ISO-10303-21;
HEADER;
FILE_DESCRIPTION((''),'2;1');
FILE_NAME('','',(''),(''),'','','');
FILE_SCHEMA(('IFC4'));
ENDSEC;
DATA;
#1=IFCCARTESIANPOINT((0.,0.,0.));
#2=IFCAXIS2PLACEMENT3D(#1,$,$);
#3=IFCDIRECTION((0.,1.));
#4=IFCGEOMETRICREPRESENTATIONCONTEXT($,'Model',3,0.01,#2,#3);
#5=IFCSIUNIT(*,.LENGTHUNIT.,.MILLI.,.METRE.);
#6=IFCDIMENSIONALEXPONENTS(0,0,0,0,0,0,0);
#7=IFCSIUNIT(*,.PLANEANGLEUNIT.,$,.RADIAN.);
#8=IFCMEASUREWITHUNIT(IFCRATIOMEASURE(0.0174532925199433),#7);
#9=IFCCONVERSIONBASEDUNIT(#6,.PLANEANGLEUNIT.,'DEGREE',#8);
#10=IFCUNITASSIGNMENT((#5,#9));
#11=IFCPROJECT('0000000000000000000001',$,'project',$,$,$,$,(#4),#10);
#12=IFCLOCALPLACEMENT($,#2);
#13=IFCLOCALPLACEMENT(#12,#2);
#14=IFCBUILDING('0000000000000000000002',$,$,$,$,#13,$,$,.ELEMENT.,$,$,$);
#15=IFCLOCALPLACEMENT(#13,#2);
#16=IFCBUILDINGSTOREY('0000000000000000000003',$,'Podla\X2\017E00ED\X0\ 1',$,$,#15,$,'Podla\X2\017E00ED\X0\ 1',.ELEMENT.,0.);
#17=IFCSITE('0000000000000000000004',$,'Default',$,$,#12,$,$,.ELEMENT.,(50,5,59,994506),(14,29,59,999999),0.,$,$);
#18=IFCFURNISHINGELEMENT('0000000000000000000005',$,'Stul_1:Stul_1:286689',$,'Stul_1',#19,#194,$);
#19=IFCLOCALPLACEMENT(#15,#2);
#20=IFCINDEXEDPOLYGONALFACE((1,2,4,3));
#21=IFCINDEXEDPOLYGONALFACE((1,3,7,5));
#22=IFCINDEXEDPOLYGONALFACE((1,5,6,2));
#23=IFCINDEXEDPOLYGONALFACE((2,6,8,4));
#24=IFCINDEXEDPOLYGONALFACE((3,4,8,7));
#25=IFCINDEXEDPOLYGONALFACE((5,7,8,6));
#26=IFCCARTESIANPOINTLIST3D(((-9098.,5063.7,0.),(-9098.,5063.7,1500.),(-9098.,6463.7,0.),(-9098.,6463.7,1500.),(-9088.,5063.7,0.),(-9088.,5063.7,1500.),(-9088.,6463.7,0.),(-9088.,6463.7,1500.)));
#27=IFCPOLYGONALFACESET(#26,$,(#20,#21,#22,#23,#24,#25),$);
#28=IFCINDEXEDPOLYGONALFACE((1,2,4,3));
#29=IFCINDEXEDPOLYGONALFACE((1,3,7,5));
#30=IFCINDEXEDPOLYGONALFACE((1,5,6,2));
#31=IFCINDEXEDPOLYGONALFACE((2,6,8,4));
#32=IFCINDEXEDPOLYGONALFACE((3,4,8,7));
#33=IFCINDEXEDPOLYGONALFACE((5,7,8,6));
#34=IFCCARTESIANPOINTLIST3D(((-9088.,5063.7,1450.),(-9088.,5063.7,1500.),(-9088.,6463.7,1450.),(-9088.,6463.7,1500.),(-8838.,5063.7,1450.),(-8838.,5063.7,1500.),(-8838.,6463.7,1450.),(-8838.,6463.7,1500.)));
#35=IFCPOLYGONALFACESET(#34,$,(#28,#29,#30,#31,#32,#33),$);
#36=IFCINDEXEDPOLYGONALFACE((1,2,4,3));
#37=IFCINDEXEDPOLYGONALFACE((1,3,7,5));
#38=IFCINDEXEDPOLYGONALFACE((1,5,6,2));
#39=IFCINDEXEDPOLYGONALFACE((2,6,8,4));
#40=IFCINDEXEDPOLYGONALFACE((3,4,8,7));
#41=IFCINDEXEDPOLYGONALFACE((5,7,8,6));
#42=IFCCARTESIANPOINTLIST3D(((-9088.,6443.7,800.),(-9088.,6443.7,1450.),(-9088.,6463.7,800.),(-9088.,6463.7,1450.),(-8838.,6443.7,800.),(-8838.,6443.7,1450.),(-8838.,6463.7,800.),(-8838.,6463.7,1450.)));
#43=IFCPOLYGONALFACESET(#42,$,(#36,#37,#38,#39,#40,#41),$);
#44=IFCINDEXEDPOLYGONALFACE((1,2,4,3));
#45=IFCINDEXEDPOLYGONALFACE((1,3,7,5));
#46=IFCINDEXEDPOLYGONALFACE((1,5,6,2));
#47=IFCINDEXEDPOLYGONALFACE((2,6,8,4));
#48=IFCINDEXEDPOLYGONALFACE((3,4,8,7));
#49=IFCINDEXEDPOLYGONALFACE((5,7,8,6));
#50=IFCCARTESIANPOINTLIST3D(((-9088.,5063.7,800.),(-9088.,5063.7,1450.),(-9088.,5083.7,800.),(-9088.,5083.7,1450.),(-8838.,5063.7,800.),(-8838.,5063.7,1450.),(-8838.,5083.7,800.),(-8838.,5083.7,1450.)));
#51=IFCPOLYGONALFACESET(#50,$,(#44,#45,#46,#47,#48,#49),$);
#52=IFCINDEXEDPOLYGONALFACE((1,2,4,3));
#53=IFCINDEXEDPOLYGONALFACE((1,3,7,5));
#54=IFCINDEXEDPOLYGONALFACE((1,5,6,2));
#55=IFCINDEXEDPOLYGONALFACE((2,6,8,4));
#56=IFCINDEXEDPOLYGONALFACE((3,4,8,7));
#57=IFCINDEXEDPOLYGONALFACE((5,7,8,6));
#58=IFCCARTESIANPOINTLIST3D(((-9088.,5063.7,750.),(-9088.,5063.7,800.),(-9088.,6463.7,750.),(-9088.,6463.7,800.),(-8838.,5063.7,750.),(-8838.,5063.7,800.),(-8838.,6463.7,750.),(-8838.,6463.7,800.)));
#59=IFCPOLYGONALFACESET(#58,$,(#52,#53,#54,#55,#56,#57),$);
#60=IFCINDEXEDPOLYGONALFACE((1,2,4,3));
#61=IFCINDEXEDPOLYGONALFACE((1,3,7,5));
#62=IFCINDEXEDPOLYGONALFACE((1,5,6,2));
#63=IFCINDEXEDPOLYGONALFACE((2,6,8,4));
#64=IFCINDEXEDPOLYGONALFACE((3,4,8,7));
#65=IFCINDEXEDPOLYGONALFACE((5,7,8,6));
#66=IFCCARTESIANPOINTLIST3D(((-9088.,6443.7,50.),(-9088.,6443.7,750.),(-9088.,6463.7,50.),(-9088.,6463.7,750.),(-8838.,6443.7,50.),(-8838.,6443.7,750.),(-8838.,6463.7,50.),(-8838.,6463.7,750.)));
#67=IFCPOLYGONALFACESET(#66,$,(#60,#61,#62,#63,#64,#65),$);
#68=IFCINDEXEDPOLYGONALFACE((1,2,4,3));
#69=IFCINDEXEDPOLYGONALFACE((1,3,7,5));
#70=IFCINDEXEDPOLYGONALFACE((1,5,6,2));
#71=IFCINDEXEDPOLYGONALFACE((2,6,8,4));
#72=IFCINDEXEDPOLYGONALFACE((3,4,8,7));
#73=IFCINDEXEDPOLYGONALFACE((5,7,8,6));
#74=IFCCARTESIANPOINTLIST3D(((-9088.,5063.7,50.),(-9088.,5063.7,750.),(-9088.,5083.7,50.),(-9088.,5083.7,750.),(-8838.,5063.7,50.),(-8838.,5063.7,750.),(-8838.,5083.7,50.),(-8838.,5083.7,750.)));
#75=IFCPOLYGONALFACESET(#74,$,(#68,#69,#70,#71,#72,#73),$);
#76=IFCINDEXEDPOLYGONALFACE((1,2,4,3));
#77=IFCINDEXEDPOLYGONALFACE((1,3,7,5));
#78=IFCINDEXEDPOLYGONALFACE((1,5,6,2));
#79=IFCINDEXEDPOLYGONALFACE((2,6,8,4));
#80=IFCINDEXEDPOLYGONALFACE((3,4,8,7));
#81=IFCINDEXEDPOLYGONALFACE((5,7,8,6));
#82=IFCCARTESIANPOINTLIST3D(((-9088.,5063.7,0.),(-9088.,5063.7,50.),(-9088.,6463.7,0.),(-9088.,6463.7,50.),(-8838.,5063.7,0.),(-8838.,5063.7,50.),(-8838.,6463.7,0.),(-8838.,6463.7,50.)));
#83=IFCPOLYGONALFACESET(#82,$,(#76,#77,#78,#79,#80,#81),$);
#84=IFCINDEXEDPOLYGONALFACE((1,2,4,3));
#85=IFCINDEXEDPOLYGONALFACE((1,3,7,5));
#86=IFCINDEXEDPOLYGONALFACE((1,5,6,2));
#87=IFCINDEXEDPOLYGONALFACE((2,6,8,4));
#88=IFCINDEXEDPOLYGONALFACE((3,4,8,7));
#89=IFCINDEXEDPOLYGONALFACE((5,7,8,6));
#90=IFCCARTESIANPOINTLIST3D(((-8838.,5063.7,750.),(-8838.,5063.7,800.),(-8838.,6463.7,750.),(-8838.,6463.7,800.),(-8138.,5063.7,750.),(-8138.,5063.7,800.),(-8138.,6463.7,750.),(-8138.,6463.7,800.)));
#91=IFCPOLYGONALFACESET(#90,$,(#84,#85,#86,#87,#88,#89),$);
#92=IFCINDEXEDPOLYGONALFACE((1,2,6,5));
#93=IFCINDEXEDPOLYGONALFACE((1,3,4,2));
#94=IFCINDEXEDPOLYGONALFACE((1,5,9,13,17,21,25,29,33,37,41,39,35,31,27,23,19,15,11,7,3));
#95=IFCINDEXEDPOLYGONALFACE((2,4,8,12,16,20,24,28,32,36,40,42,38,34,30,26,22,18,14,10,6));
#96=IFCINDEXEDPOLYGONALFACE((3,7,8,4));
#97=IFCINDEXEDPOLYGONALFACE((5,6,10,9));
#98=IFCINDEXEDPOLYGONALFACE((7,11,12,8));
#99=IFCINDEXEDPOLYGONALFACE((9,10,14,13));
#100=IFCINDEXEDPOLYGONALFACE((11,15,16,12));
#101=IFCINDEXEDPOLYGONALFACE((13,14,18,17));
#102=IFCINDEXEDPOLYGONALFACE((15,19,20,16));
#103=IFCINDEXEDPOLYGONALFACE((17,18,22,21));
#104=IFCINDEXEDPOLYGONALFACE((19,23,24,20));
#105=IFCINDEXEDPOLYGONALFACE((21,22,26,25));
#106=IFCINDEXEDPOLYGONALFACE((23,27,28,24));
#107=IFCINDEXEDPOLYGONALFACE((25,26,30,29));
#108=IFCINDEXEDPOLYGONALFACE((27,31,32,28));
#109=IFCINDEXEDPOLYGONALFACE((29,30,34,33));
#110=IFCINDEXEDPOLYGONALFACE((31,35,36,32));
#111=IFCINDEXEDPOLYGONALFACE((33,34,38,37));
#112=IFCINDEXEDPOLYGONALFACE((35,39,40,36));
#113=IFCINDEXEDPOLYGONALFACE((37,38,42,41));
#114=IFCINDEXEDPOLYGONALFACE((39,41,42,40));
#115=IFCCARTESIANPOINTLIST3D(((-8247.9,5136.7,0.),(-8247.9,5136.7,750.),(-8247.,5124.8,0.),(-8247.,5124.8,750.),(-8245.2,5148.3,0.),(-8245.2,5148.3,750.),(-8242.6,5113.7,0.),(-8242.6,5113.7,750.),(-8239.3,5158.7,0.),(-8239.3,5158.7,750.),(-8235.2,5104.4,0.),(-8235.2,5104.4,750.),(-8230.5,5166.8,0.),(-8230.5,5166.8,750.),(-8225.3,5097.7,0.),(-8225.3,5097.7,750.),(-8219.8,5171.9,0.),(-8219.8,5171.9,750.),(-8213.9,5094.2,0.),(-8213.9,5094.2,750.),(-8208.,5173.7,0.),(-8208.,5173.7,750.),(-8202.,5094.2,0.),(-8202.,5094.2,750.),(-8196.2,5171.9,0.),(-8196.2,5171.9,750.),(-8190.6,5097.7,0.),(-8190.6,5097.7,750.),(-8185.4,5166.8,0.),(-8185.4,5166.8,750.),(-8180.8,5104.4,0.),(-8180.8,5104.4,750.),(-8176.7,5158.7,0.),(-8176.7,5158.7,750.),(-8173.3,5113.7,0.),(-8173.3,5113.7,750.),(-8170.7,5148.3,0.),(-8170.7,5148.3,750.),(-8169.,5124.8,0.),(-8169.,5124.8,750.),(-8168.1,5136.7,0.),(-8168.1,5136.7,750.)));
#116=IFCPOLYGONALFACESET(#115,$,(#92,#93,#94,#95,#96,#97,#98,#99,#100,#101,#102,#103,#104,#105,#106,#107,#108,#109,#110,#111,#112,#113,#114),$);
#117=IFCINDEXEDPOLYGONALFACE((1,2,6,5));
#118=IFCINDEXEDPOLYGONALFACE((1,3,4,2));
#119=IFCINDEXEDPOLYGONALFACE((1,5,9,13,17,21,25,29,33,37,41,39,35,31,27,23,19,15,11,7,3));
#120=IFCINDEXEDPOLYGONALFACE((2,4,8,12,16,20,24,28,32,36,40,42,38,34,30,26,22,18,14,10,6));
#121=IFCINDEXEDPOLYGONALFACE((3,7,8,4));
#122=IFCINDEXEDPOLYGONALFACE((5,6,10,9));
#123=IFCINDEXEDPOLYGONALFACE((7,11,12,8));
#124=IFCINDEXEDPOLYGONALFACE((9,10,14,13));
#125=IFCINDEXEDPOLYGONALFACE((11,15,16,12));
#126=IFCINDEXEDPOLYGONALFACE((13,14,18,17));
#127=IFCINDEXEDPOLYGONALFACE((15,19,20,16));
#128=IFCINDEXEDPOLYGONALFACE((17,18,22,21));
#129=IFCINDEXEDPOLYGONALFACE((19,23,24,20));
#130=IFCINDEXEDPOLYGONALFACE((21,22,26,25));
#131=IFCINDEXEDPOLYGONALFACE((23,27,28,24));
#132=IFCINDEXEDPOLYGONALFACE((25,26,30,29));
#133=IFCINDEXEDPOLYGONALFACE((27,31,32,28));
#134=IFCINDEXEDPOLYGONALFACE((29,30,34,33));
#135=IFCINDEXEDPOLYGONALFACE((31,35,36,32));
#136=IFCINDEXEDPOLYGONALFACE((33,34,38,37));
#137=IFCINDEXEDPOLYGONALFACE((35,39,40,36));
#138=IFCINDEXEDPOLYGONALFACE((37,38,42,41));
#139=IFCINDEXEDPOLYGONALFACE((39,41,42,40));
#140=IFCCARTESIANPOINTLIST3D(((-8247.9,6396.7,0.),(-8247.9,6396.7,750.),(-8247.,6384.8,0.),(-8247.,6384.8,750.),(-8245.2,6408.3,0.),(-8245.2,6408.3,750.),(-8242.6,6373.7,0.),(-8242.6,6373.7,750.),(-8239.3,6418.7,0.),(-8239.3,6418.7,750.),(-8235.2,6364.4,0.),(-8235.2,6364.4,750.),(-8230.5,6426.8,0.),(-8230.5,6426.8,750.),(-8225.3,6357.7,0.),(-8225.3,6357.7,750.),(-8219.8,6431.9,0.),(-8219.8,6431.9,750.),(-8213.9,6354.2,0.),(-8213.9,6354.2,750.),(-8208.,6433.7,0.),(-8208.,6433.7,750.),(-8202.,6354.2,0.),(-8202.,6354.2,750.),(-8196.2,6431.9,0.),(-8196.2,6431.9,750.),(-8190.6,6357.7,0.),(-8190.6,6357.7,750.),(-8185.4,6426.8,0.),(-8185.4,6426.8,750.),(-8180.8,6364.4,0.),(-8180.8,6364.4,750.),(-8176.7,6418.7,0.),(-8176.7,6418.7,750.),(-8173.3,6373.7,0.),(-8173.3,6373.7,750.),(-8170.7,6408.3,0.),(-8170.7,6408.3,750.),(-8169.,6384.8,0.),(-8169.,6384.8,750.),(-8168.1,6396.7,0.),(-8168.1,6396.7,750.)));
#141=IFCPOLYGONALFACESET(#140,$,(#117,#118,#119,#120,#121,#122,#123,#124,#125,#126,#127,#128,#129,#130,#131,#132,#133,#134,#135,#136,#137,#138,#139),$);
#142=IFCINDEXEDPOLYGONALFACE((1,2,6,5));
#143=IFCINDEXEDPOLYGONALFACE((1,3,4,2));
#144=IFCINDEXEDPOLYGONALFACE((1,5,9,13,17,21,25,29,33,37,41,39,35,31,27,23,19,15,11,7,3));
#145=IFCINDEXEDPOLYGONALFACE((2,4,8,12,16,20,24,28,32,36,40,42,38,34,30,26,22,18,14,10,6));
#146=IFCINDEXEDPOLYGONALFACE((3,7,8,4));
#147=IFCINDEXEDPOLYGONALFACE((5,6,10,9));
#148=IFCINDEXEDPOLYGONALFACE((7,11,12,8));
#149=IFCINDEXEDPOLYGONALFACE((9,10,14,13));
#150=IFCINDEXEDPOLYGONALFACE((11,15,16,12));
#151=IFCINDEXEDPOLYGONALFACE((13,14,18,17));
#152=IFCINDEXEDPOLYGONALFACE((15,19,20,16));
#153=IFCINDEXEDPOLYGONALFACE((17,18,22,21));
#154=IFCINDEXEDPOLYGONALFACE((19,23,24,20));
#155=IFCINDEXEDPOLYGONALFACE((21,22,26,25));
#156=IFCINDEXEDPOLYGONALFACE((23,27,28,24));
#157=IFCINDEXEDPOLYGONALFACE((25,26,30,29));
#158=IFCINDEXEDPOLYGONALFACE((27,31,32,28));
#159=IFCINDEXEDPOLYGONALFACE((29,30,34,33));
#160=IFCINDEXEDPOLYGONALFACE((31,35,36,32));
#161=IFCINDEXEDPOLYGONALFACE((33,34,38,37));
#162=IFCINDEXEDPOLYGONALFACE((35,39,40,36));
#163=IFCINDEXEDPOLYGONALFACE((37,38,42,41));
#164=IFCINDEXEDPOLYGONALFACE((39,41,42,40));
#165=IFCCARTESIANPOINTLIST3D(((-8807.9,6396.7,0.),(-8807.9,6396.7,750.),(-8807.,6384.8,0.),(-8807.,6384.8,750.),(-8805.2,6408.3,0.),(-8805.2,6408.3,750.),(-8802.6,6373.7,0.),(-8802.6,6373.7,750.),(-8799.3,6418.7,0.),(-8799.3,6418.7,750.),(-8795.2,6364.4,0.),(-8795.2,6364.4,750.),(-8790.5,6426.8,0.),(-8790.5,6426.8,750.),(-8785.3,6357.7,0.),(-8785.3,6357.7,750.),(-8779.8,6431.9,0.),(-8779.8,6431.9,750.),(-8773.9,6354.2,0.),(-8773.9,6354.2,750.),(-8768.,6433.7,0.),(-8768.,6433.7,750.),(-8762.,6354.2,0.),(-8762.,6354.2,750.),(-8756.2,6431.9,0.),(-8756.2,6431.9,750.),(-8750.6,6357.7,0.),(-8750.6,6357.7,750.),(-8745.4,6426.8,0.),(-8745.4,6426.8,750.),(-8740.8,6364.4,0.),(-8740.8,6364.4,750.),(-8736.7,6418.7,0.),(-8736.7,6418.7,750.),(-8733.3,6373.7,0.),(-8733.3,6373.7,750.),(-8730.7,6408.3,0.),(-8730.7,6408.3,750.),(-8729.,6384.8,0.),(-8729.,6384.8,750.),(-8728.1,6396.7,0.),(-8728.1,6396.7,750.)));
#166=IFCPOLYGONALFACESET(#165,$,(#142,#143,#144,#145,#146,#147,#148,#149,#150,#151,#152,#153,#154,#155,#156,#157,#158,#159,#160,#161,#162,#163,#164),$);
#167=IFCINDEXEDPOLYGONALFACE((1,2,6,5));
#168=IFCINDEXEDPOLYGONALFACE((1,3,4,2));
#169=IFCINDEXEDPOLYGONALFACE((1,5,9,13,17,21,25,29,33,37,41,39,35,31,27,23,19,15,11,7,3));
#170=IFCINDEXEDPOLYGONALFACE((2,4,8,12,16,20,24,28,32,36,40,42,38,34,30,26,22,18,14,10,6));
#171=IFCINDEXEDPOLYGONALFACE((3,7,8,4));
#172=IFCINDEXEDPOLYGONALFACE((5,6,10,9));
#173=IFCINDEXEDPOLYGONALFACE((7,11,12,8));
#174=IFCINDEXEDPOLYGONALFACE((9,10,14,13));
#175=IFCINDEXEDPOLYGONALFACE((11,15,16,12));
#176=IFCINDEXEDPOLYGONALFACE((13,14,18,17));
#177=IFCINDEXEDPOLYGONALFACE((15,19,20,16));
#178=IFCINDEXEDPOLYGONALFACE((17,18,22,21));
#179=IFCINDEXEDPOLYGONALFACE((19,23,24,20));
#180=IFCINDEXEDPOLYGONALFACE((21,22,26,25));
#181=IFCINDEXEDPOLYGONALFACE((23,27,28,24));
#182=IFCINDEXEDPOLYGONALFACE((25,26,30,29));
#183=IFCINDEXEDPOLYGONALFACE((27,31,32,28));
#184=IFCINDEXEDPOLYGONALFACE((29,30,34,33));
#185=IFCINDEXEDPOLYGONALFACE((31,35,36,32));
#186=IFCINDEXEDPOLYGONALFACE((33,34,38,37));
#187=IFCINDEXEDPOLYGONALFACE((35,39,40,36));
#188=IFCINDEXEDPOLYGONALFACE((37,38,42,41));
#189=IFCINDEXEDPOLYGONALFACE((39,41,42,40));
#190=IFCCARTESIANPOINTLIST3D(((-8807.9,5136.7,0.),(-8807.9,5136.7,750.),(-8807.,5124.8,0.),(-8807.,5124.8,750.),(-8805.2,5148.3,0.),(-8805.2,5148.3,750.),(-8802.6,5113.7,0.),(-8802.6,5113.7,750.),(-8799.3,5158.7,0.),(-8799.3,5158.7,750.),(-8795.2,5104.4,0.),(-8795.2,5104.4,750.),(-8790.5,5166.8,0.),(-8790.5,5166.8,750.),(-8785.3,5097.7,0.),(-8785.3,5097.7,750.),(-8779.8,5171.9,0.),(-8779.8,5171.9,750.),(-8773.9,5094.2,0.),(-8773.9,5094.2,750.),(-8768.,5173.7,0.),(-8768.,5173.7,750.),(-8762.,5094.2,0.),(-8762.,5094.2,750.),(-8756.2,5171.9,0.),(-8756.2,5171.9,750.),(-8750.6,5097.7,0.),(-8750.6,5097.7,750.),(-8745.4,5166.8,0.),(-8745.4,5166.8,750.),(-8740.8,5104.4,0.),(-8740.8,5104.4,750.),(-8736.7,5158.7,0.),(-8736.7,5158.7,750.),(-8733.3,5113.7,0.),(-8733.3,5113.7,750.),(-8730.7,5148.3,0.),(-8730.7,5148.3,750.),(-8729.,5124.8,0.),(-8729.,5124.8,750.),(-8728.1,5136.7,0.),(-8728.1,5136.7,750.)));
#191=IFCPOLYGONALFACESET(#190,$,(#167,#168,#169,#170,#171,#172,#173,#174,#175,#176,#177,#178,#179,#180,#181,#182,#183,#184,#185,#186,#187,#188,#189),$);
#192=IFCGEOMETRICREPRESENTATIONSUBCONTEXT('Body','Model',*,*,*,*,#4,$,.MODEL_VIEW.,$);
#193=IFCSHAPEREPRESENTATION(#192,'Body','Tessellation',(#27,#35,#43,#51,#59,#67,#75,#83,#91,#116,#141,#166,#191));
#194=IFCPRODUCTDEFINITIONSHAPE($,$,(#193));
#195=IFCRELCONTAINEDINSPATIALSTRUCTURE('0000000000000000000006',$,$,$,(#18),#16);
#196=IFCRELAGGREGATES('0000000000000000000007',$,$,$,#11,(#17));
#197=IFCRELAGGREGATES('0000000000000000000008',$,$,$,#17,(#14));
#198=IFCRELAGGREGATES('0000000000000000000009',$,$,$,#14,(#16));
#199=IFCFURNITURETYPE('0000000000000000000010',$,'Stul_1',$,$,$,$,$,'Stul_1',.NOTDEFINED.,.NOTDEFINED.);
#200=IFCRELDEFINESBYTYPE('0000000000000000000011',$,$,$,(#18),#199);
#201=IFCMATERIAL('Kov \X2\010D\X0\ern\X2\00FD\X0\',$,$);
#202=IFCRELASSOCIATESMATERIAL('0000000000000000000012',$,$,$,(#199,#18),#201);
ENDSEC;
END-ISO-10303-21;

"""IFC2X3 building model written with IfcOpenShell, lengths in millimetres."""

from ifc_helpers import new_model, entity, si_unit, converted_unit, direction, frame, frame_2d, origin, origin_2d_with_axis, place, context, subcontext, project, spatial, rectangle, circle, extrude, source, transform, mapped, material, type_object, type_shapes, element, save


model = new_model("IFC2X3")

# Units and contexts
model_context = context("Model", 3, precision=0.01, world=origin(), true_north=direction((0.0, 1.0)))
body_context = subcontext(model_context, "Body", "Model", "MODEL_VIEW")
ifc_project = project(units=[si_unit("LENGTHUNIT", "METRE", prefix="MILLI"), converted_unit("PLANEANGLEUNIT", "DEGREE", entity("IfcRatioMeasure", 0.0174532925199433), si_unit("PLANEANGLEUNIT", "RADIAN"), dimensions=[0, 0, 0, 0, 0, 0, 0])], contexts=[model_context])

# Site, building, storey
site_placement = place(None, origin())
site = spatial("IfcSite", under=ifc_project, at=site_placement, Name="Default", CompositionType="ELEMENT", RefLatitude=(50, 5, 59, 994506), RefLongitude=(14, 29, 59, 999999), RefElevation=0.0)
building_placement = place(site_placement, origin())
building = spatial("IfcBuilding", under=site, at=building_placement, CompositionType="ELEMENT")
storey_placement = place(building_placement, origin())
storey = spatial("IfcBuildingStorey", under=building, at=storey_placement, Name="Podlaží 1", LongName="Podlaží 1", CompositionType="ELEMENT", Elevation=0.0)

# Furnishing element
ifc_material_1 = material(Name="Kov černý")
furniture_type = type_object("IfcFurnitureType", Name="Stul_1", ElementType="Stul_1", material=ifc_material_1)
shared_shape_1 = source(origin(), body_context, "Body", "SweptSolid", [
    extrude(rectangle(XDim=1400.0, YDim=10.0, at=origin_2d_with_axis()), frame((0.0, 605.0, 0.0), z_axis=(0.0, 0.0, 1.0), x_axis=(-1.0, 0.0, 0.0)), (0.0, 0.0, 1.0), 1500.0),
    extrude(rectangle(XDim=1400.0, YDim=250.0, at=frame_2d((0.0, 0.0), x_axis=(1.0, 0.0))), frame((0.0, 475.0, 1450.0), z_axis=(0.0, 0.0, 1.0), x_axis=(-1.0, 0.0, 0.0)), (0.0, 0.0, 1.0), 50.0),
    extrude(rectangle(XDim=20.0, YDim=250.0, at=origin_2d_with_axis()), frame((690.0, 475.0, 800.0), z_axis=(0.0, 0.0, 1.0), x_axis=(-1.0, 0.0, 0.0)), (0.0, 0.0, 1.0), 650.0),
    extrude(rectangle(XDim=20.0, YDim=250.0, at=frame_2d((0.0, 0.0), x_axis=(1.0, 0.0))), frame((-690.0, 475.0, 800.0), z_axis=(0.0, 0.0, 1.0), x_axis=(-1.0, 0.0, 0.0)), (0.0, 0.0, 1.0), 650.0),
    extrude(rectangle(XDim=1400.0, YDim=250.0, at=origin_2d_with_axis()), frame((0.0, 475.0, 750.0), z_axis=(0.0, 0.0, 1.0), x_axis=(-1.0, 0.0, 0.0)), (0.0, 0.0, 1.0), 50.0),
    extrude(rectangle(XDim=20.0, YDim=250.0, at=origin_2d_with_axis()), frame((690.0, 475.0, 50.0), z_axis=(0.0, 0.0, 1.0), x_axis=(-1.0, 0.0, 0.0)), (0.0, 0.0, 1.0), 700.0),
    extrude(rectangle(XDim=20.0, YDim=250.0, at=frame_2d((0.0, 0.0), x_axis=(1.0, 0.0))), frame((-690.0, 475.0, 50.0), z_axis=(0.0, 0.0, 1.0), x_axis=(-1.0, 0.0, 0.0)), (0.0, 0.0, 1.0), 700.0),
    extrude(rectangle(XDim=1400.0, YDim=250.0, at=origin_2d_with_axis()), frame((0.0, 475.0, 0.0), z_axis=(0.0, 0.0, 1.0), x_axis=(-1.0, 0.0, 0.0)), (0.0, 0.0, 1.0), 50.0),
    extrude(rectangle(XDim=1400.0, YDim=700.0, at=origin_2d_with_axis()), frame((0.0, 0.0, 750.0), z_axis=(0.0, 0.0, 1.0), x_axis=(-1.0, 0.0, 0.0)), (0.0, 0.0, 1.0), 50.0),
    extrude(circle(Radius=40.0, at=frame_2d((0.0, 0.0), x_axis=(1.0, 0.0))), frame((-630.0, -280.0, 0.0)), (0.0, 0.0, 1.0), 750.0),
    extrude(circle(Radius=40.0, at=frame_2d((0.0, 0.0), x_axis=(1.0, 0.0))), frame((630.0, -280.0, 0.0)), (0.0, 0.0, 1.0), 750.0),
    extrude(circle(Radius=40.0, at=frame_2d((0.0, 0.0), x_axis=(1.0, 0.0))), frame((630.0, 280.0, 0.0)), (0.0, 0.0, 1.0), 750.0),
    extrude(circle(Radius=40.0, at=frame_2d((0.0, 0.0), x_axis=(1.0, 0.0))), frame((-630.0, 280.0, 0.0)), (0.0, 0.0, 1.0), 750.0),
])
type_shapes(furniture_type, [shared_shape_1])
for number, where, z_axis, x_axis, name in (
    (1, (-8488.0, 5763.7, 0.0), (0.0, 0.0, 1.0), (0.0, 1.0, 0.0), "Stul_1:Stul_1:286689"),
):
    element("IfcFurnishingElement", number, at=place(storey_placement, frame(where, z_axis=z_axis, x_axis=x_axis)), inside=storey, type_object=furniture_type, material=ifc_material_1, Name=name, ObjectType="Stul_1", context=body_context, shape_type="MappedRepresentation", body=[
        mapped(shared_shape_1, transform((0.0, 0.0, 0.0), scale=1.0)),
    ])

save(model, "model.ifc")
